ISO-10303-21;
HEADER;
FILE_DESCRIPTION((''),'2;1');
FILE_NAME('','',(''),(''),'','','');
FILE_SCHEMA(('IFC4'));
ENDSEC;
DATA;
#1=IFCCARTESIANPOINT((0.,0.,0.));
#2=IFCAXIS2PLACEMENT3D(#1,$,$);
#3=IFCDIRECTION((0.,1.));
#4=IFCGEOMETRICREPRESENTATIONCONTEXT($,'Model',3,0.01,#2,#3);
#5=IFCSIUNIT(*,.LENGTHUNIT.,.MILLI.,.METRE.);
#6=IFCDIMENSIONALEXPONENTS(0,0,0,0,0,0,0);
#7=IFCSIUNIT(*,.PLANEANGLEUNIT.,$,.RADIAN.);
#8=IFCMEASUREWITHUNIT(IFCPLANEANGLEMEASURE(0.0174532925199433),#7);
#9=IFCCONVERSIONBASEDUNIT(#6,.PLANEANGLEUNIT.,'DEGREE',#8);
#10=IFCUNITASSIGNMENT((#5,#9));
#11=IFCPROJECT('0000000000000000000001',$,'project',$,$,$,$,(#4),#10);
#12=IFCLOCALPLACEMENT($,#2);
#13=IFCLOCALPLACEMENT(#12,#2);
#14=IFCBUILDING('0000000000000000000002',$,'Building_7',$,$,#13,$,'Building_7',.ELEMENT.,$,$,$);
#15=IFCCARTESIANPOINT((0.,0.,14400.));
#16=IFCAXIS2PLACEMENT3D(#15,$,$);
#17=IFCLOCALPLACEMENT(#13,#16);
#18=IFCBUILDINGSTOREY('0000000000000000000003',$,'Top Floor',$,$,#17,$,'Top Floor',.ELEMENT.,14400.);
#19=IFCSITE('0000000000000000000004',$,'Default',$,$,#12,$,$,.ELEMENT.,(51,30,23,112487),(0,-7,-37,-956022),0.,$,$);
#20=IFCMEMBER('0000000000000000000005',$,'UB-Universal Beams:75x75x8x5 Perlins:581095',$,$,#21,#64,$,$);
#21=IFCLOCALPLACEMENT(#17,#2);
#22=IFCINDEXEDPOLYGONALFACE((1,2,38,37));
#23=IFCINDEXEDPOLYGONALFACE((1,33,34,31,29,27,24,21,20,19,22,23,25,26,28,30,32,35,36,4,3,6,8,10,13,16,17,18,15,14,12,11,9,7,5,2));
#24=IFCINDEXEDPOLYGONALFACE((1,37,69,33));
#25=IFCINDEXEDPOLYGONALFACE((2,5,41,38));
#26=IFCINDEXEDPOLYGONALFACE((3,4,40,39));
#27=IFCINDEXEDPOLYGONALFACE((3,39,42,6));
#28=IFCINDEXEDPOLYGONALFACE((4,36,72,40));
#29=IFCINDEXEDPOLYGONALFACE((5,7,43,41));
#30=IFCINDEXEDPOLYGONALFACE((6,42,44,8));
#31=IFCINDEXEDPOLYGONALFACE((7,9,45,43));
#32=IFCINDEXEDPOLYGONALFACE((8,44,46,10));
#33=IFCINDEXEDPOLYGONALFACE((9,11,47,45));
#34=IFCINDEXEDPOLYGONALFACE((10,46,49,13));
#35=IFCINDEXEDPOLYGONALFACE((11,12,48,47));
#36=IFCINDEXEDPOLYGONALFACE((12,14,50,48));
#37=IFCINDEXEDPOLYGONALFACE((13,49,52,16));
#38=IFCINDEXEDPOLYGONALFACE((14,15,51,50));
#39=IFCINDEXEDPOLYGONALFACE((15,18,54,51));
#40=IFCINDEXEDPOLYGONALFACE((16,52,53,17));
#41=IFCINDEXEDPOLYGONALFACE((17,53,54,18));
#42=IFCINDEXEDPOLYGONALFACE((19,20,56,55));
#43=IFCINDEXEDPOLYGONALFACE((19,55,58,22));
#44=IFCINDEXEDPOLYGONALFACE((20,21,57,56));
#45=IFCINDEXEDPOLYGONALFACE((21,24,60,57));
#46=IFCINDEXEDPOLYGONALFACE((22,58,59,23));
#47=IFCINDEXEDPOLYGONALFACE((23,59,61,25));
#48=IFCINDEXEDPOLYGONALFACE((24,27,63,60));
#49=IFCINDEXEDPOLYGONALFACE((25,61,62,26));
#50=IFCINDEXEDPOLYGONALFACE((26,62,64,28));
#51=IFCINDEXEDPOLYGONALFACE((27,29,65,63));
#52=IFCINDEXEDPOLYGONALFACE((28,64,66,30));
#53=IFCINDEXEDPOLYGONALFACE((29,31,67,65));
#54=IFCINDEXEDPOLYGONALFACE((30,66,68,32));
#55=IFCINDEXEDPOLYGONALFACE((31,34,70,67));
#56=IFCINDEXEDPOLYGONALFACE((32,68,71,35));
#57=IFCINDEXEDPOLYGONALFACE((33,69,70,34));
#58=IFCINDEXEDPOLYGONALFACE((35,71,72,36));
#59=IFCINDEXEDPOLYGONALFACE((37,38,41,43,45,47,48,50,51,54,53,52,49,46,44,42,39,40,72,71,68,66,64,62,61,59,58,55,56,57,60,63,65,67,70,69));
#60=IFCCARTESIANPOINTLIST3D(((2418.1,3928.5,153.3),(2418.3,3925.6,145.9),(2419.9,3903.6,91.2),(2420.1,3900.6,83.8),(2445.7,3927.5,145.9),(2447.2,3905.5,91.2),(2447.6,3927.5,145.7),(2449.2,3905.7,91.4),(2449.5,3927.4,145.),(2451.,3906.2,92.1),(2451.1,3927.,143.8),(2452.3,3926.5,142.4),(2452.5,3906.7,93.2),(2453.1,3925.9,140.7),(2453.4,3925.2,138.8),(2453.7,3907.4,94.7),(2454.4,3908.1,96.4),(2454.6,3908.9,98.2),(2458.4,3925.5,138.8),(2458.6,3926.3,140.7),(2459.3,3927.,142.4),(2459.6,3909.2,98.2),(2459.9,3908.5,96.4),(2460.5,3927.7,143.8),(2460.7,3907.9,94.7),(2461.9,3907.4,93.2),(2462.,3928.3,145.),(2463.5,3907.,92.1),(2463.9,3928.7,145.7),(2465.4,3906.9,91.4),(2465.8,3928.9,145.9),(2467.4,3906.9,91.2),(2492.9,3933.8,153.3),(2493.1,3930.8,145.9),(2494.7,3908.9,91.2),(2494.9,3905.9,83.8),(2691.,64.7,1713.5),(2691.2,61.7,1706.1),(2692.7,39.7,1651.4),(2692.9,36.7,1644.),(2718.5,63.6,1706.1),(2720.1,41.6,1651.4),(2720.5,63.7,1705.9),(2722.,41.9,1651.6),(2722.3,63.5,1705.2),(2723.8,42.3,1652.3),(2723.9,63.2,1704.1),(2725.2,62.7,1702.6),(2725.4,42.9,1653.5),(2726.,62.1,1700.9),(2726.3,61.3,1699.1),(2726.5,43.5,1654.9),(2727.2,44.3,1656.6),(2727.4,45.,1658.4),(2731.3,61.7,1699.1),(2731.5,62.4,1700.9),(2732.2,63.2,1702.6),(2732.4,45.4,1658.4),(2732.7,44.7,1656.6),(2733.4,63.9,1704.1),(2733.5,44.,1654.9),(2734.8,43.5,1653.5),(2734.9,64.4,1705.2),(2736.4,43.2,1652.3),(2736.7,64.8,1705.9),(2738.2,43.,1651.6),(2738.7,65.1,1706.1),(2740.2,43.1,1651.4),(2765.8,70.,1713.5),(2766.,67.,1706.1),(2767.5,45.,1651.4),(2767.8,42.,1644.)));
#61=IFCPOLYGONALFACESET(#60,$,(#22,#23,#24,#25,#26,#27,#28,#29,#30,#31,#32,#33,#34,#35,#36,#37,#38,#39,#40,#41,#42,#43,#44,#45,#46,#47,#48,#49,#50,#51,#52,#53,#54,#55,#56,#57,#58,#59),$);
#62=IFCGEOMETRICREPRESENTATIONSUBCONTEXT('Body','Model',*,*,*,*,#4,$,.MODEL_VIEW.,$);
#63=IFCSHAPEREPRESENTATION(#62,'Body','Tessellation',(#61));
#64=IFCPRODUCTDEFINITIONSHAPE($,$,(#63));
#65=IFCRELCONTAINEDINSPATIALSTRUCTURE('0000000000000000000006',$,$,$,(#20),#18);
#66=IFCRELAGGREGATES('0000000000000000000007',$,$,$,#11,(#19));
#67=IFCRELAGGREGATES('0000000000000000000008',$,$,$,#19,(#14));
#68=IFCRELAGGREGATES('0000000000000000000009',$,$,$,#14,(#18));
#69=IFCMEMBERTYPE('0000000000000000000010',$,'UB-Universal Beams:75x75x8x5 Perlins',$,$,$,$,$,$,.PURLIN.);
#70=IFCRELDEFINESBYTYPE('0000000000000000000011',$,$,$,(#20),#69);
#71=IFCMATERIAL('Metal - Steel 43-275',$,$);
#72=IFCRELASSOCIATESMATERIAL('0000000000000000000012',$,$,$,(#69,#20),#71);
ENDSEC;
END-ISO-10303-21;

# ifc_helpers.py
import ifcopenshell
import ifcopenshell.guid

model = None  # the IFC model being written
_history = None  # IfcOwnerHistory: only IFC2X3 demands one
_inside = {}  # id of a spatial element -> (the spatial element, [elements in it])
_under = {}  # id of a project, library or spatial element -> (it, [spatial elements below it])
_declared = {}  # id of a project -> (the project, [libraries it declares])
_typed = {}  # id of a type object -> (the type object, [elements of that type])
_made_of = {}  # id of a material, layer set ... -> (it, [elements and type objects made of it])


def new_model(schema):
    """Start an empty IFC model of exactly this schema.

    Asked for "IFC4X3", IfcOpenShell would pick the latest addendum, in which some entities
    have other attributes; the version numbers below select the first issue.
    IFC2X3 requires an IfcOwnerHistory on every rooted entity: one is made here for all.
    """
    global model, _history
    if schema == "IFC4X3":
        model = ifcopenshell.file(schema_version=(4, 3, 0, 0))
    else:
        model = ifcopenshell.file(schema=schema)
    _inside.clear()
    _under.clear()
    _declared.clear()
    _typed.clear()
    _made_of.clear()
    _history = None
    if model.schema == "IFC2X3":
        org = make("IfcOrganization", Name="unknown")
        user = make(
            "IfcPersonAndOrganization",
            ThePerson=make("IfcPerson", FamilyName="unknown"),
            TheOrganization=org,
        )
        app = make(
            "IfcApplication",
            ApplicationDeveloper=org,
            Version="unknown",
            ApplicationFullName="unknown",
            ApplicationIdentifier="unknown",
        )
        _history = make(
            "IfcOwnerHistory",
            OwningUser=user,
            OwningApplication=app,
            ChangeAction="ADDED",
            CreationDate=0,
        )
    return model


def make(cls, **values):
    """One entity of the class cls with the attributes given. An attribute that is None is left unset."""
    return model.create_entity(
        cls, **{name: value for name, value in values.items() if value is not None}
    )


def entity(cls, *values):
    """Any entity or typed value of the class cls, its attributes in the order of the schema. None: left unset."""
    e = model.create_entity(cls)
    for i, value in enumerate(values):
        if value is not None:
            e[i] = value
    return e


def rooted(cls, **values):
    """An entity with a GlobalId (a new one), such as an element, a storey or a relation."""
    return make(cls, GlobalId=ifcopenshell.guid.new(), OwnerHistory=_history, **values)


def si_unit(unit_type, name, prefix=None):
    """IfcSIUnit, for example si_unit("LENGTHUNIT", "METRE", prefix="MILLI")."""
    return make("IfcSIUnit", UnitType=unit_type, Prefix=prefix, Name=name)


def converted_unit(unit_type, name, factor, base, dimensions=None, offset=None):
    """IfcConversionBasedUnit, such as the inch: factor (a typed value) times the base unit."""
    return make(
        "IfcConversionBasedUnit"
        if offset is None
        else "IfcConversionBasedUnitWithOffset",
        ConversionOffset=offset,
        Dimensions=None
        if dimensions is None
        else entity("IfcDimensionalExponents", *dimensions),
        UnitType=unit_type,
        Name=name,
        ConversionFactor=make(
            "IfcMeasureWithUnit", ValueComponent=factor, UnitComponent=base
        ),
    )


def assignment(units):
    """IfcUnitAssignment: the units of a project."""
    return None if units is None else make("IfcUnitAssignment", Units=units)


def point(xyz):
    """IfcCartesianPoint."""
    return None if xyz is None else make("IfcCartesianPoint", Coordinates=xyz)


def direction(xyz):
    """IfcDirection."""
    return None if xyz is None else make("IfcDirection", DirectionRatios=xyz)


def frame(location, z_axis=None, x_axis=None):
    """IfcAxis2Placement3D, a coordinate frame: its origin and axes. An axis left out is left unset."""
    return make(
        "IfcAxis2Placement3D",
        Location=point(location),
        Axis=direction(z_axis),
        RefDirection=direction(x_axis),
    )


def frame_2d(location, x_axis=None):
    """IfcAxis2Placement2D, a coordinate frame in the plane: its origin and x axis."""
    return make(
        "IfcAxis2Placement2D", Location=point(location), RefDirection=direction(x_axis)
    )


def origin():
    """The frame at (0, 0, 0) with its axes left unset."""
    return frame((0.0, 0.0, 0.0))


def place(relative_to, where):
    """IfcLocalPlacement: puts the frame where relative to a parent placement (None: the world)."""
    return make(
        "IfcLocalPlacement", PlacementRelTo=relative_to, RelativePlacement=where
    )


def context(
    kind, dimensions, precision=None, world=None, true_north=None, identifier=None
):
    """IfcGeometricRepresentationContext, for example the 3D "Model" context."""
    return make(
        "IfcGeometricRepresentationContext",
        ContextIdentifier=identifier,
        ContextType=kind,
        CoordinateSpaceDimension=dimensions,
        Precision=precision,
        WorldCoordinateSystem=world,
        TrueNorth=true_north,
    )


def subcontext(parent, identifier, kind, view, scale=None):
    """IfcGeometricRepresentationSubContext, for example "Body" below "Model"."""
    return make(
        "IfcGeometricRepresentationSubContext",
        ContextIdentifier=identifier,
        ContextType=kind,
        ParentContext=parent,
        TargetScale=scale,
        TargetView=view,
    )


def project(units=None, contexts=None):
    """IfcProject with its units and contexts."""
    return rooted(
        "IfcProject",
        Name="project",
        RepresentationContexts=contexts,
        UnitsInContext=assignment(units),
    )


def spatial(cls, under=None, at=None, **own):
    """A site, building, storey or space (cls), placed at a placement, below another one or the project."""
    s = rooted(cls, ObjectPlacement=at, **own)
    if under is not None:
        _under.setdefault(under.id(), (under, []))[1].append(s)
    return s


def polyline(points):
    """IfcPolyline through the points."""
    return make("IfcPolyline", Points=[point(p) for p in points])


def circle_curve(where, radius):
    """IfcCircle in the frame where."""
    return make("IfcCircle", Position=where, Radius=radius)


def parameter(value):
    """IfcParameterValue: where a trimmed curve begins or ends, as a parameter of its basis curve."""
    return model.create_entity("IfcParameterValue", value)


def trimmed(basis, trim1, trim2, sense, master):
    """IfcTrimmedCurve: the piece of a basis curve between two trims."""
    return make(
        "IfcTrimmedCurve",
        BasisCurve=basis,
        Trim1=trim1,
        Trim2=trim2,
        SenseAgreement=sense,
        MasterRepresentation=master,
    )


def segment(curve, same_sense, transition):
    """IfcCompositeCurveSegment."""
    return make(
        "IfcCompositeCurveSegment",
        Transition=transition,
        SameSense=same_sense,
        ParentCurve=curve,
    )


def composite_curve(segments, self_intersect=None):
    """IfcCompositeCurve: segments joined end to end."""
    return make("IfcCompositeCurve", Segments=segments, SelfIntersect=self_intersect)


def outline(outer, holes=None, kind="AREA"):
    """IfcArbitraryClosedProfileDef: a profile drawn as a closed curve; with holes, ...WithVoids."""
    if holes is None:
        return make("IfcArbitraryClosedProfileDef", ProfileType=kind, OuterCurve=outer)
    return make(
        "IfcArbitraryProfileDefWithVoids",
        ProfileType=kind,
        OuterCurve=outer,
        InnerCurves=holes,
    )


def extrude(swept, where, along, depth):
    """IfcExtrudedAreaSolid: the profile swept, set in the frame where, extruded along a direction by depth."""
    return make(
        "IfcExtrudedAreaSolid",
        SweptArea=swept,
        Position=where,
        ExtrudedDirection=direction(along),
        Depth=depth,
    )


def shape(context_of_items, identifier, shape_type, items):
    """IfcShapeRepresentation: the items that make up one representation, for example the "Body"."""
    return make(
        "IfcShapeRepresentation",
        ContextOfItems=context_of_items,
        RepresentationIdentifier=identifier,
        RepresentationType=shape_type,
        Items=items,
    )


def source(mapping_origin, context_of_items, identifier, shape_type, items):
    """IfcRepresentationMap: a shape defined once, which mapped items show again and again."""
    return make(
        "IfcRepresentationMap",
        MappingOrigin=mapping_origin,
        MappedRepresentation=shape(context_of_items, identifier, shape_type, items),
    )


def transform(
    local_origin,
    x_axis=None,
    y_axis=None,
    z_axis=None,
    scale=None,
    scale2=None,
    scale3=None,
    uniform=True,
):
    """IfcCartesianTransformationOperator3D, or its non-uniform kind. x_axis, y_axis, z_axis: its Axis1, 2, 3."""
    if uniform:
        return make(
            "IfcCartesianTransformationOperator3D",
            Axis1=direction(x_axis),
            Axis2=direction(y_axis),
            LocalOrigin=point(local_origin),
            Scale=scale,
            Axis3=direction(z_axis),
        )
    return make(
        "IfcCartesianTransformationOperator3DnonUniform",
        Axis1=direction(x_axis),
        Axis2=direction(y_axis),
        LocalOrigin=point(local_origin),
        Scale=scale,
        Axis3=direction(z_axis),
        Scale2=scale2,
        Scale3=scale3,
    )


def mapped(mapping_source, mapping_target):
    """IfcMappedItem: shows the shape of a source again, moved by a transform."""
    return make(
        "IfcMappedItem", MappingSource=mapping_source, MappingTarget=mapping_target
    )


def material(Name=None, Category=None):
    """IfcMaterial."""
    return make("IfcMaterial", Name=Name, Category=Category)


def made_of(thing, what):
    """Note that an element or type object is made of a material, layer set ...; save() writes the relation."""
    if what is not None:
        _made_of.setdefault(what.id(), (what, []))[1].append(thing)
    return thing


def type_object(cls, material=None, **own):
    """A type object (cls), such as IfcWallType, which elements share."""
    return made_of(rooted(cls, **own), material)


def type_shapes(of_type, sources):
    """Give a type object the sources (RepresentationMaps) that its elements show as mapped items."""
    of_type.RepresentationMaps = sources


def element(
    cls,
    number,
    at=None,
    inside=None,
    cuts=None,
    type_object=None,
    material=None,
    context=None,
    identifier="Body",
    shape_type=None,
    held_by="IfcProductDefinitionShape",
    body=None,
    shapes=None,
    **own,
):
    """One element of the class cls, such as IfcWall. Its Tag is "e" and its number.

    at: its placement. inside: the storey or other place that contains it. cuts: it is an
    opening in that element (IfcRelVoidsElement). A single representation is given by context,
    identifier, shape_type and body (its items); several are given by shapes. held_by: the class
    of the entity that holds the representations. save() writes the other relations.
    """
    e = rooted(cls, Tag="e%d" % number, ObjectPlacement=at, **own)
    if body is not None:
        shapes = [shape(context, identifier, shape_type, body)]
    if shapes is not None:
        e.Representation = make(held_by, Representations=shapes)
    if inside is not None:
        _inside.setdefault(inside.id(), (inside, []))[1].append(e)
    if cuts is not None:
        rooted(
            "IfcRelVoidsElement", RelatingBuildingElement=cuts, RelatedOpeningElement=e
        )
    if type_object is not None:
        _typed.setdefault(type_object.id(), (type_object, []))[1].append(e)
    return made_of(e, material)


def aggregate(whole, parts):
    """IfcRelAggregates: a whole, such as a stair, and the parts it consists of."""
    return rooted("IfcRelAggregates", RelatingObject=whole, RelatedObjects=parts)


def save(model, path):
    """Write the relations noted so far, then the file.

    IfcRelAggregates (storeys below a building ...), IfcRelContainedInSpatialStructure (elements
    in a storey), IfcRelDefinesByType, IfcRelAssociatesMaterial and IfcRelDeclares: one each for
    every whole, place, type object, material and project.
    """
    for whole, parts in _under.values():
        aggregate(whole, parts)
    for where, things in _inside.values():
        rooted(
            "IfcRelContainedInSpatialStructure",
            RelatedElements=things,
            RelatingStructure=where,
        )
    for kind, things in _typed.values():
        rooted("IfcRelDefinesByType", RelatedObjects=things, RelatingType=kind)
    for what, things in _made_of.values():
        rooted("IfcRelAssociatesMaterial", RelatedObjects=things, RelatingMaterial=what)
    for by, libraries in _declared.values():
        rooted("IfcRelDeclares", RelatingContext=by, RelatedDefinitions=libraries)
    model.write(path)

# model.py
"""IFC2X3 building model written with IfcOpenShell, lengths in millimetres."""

from ifc_helpers import new_model, entity, si_unit, converted_unit, direction, frame, frame_2d, origin, place, context, subcontext, project, spatial, polyline, circle_curve, parameter, trimmed, segment, composite_curve, outline, extrude, source, transform, mapped, material, type_object, type_shapes, element, save


model = new_model("IFC2X3")

# Units and contexts
model_context = context("Model", 3, precision=0.01, world=origin(), true_north=direction((0.0, 1.0)))
body_context = subcontext(model_context, "Body", "Model", "MODEL_VIEW")
ifc_project = project(units=[si_unit("LENGTHUNIT", "METRE", prefix="MILLI"), converted_unit("PLANEANGLEUNIT", "DEGREE", entity("IfcPlaneAngleMeasure", 0.0174532925199433), si_unit("PLANEANGLEUNIT", "RADIAN"), dimensions=[0, 0, 0, 0, 0, 0, 0])], contexts=[model_context])

# Site, building, storey
site_placement = place(None, origin())
site = spatial("IfcSite", under=ifc_project, at=site_placement, Name="Default", CompositionType="ELEMENT", RefLatitude=(51, 30, 23, 112487), RefLongitude=(0, -7, -37, -956022), RefElevation=0.0)
building_placement = place(site_placement, origin())
building = spatial("IfcBuilding", under=site, at=building_placement, Name="Building_7", LongName="Building_7", CompositionType="ELEMENT")
storey_placement = place(building_placement, frame((0.0, 0.0, 14400.0)))
storey = spatial("IfcBuildingStorey", under=building, at=storey_placement, Name="Top Floor", LongName="Top Floor", CompositionType="ELEMENT", Elevation=14400.0)

# Shared definitions
ifc_material = material(Name="Metal - Steel 43-275")

# Member
member_type_1 = type_object("IfcMemberType", Name="UB-Universal Beams:75x75x8x5 Perlins", PredefinedType="PURLIN", material=ifc_material)
shared_shape_1 = source(origin(), body_context, "Body", "SweptSolid", [
    extrude(outline(composite_curve([segment(polyline([(29.5, -37.5), (37.5, -37.5)]), True, "CONTINUOUS"), segment(polyline([(37.5, -37.5), (37.5, 37.5)]), True, "CONTINUOUS"), segment(polyline([(37.5, 37.5), (29.5, 37.5)]), True, "CONTINUOUS"), segment(polyline([(29.5, 37.5), (29.5, 10.1)]), True, "CONTINUOUS"), segment(trimmed(circle_curve(frame_2d((21.9, 10.1), x_axis=(0.0, 1.0)), 7.6), [parameter(180.0)], [parameter(270.0)], True, "PARAMETER"), False, "CONTINUOUS"), segment(polyline([(21.9, 2.5), (-21.9, 2.5)]), True, "CONTINUOUS"), segment(trimmed(circle_curve(frame_2d((-21.9, 10.1), x_axis=(0.0, 1.0)), 7.6), [parameter(90.0)], [parameter(180.0)], True, "PARAMETER"), False, "CONTINUOUS"), segment(polyline([(-29.5, 10.1), (-29.5, 37.5)]), True, "CONTINUOUS"), segment(polyline([(-29.5, 37.5), (-37.5, 37.5)]), True, "CONTINUOUS"), segment(polyline([(-37.5, 37.5), (-37.5, -37.5)]), True, "CONTINUOUS"), segment(polyline([(-37.5, -37.5), (-29.5, -37.5)]), True, "CONTINUOUS"), segment(polyline([(-29.5, -37.5), (-29.5, -10.1)]), True, "CONTINUOUS"), segment(trimmed(circle_curve(frame_2d((-21.9, -10.1), x_axis=(0.0, 1.0)), 7.6), [parameter(360.0)], [parameter(90.0)], True, "PARAMETER"), False, "CONTINUOUS"), segment(polyline([(-21.9, -2.5), (21.9, -2.5)]), True, "CONTINUOUS"), segment(trimmed(circle_curve(frame_2d((21.9, -10.1), x_axis=(0.0, 1.0)), 7.6), [parameter(270.0)], [parameter(360.0)], True, "PARAMETER"), False, "CONTINUOUS"), segment(polyline([(29.5, -10.1), (29.5, -37.5)]), True, "CONTINUOUS")], self_intersect=False)), frame((-2087.9, 0.0, 0.0), z_axis=(1.0, 0.0, 0.0), x_axis=(0.0, 0.0, -1.0)), (0.0, 0.0, 1.0), 4175.9),
])
type_shapes(member_type_1, [shared_shape_1])
member_1_placement = place(storey_placement, frame((2592.9, 1985.3, 898.6), z_axis=(-0.026318, 0.372698, 0.927579), x_axis=(0.065339, -0.925275, 0.373626)))
element("IfcMember", 1, at=member_1_placement, inside=storey, type_object=member_type_1, material=ifc_material, Name="UB-Universal Beams:75x75x8x5 Perlins:581095", context=body_context, shape_type="MappedRepresentation", body=[
    mapped(shared_shape_1, transform((0.0, 0.0, 0.0), scale=1.0)),
])

save(model, "model.ifc")
